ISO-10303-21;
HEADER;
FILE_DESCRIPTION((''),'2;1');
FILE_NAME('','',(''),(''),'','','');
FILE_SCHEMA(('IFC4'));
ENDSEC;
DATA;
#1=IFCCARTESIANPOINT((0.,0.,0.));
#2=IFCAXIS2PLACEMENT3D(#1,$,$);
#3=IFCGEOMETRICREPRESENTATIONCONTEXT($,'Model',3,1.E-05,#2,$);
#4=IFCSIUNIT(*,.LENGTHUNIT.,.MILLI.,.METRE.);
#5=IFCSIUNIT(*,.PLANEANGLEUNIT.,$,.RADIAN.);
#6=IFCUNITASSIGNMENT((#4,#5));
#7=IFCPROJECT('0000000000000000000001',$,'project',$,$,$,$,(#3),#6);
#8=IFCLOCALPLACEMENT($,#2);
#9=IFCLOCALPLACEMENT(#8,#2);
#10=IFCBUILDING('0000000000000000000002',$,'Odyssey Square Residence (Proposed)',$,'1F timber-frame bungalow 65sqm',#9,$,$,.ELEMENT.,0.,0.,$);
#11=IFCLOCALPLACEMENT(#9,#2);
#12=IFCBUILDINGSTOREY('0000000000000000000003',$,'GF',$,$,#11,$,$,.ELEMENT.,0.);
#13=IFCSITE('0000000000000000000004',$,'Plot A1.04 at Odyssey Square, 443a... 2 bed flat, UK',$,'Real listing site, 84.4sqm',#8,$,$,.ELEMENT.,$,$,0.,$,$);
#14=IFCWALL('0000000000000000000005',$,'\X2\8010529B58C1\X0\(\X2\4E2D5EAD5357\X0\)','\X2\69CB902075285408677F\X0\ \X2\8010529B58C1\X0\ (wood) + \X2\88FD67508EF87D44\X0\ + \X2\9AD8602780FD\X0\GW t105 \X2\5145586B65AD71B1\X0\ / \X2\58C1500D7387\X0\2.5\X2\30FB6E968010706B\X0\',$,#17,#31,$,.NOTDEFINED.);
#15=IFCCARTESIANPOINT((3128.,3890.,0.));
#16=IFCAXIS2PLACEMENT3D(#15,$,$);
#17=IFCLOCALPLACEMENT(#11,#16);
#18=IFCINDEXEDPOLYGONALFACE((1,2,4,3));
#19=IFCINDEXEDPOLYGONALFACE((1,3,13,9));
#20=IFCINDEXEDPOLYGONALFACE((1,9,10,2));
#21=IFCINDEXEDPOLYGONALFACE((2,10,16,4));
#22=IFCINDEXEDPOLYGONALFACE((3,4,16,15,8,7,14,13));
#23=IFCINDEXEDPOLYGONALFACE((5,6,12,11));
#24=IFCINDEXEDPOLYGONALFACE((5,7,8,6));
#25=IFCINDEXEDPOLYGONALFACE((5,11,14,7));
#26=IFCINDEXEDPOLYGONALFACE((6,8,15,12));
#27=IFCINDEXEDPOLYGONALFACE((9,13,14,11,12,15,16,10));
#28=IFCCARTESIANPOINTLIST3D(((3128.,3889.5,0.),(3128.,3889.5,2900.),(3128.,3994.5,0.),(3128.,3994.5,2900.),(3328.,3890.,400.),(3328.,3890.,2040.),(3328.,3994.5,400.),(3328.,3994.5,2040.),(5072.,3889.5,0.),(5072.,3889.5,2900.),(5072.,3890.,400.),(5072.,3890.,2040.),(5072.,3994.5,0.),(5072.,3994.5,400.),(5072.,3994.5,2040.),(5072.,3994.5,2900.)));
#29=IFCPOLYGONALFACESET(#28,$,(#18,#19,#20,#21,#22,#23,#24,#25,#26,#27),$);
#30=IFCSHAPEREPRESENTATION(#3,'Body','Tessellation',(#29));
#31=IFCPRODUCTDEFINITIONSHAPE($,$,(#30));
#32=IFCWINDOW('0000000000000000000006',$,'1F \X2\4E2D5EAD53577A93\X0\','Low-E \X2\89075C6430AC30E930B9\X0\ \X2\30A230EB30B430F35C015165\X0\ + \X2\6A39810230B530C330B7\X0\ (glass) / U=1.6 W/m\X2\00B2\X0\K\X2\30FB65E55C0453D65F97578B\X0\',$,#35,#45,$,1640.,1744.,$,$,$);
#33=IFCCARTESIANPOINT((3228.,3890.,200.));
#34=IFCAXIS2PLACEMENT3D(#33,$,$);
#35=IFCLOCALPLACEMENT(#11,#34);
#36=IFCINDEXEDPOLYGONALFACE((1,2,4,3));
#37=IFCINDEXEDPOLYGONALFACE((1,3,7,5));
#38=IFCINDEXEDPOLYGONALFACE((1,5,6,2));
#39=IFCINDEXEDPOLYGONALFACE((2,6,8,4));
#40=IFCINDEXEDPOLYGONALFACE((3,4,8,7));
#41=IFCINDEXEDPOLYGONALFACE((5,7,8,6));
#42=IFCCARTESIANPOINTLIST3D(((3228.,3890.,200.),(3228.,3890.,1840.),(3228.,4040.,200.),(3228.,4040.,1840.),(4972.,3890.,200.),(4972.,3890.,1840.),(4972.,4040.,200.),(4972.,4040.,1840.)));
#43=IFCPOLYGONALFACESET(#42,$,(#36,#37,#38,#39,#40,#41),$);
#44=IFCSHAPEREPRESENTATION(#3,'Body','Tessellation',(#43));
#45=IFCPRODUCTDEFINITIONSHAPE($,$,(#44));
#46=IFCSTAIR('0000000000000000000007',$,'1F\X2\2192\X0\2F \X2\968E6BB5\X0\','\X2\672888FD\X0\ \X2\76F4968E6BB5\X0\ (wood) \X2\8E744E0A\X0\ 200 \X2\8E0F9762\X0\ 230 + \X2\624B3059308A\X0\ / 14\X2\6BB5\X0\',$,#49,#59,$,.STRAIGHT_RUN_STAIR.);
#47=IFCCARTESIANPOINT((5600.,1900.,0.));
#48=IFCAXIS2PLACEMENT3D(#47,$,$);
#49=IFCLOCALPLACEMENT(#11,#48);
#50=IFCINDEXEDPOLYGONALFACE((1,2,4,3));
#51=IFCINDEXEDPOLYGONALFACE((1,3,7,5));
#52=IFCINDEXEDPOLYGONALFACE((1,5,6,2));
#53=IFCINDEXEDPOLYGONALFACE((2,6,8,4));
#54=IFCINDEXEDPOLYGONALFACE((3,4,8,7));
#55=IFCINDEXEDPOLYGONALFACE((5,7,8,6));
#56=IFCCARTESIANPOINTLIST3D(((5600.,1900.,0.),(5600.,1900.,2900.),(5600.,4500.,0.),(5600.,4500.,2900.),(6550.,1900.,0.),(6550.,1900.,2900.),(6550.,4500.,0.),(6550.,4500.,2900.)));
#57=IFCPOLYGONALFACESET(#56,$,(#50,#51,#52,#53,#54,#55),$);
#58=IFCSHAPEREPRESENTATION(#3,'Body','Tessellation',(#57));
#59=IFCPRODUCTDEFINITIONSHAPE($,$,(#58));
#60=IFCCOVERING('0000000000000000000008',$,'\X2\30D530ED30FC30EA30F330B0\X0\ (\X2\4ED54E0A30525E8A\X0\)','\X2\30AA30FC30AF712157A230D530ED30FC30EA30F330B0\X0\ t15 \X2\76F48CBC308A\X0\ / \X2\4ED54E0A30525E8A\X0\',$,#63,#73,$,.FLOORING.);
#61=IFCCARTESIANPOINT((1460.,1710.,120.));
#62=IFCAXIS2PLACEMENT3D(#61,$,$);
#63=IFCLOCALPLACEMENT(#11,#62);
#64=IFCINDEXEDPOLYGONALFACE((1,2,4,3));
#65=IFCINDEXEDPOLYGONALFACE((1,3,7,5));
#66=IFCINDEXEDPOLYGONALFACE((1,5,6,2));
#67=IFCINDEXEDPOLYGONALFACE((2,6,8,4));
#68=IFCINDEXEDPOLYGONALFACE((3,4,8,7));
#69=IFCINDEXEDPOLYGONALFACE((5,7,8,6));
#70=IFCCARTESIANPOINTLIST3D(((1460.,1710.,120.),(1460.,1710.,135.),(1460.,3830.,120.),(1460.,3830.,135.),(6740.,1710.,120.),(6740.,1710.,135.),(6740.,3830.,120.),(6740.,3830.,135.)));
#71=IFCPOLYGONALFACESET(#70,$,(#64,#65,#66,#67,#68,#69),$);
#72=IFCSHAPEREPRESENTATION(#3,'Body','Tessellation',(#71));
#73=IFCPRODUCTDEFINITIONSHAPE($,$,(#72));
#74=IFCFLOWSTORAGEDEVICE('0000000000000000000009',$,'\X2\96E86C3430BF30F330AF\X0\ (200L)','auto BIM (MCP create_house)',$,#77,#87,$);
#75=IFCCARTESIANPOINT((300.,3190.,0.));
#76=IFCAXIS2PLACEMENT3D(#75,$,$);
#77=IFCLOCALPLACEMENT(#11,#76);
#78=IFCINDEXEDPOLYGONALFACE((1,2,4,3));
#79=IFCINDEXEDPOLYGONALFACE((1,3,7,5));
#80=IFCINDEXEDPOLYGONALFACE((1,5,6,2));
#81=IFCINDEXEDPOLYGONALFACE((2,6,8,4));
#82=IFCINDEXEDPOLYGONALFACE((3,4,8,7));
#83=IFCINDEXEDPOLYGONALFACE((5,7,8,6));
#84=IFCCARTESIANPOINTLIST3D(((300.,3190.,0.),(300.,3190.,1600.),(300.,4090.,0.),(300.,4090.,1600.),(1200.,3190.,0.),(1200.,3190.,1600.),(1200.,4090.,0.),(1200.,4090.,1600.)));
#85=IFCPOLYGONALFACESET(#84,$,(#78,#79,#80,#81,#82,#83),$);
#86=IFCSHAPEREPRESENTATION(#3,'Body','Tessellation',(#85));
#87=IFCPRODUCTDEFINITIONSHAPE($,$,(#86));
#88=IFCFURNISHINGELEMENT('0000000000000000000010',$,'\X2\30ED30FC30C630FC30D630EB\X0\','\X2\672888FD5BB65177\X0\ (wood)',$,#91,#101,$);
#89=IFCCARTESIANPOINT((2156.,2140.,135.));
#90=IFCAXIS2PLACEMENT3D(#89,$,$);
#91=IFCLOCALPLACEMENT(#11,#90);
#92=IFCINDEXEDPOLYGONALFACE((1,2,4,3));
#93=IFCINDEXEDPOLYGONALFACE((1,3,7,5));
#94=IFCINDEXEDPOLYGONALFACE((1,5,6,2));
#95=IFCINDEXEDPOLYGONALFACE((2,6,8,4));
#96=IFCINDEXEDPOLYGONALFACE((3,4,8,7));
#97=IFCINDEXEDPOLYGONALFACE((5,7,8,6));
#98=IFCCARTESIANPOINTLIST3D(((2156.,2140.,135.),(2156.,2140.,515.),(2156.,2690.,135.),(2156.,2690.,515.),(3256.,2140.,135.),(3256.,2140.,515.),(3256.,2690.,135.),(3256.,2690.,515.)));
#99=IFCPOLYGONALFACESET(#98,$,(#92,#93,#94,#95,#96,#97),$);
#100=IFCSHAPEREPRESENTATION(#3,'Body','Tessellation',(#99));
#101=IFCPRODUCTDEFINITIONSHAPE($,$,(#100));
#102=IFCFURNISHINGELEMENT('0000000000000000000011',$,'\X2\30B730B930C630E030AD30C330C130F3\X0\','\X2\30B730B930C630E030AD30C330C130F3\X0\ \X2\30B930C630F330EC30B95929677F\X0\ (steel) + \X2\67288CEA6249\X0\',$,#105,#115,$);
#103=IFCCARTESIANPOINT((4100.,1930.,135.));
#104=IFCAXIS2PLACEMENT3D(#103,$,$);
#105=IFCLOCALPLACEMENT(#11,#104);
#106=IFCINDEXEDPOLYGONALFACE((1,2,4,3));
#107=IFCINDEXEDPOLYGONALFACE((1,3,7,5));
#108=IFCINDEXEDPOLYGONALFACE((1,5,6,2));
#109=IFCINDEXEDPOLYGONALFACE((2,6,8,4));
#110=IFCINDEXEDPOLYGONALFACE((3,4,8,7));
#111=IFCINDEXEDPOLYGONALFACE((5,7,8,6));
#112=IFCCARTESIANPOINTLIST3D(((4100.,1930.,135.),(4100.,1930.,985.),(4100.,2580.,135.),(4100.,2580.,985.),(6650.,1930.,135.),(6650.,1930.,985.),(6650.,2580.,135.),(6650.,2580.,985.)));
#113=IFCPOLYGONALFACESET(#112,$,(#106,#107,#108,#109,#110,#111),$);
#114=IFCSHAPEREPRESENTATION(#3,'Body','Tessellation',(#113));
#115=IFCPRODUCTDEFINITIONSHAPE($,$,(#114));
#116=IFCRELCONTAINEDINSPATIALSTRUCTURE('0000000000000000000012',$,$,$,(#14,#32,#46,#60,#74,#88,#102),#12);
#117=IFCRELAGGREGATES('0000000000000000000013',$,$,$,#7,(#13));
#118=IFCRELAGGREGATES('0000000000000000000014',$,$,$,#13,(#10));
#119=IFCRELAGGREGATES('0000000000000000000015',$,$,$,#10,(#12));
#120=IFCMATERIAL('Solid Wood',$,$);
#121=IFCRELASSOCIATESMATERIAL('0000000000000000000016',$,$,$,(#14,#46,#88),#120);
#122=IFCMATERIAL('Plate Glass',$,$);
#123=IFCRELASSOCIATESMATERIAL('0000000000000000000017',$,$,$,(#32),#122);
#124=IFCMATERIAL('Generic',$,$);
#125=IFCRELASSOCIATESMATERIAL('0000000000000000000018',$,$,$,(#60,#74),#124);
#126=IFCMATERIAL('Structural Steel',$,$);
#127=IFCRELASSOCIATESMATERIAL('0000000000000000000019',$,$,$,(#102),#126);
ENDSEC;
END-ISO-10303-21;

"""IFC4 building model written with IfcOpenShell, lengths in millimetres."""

from ifc_helpers import new_model, si_unit, frame, frame_2d, origin, place, context, project, spatial, rectangle, extrude, material, element, fill, save


model = new_model("IFC4")

# Units and contexts
model_context = context("Model", 3, precision=1e-05, world=origin())
ifc_project = project(units=[si_unit("LENGTHUNIT", "METRE", prefix="MILLI"), si_unit("PLANEANGLEUNIT", "RADIAN")], contexts=[model_context])

# Site, building, storey
site_placement = place(None, origin())
site = spatial("IfcSite", under=ifc_project, at=site_placement, Name="Plot A1.04 at Odyssey Square, 443a... 2 bed flat, UK", ObjectType="Real listing site, 84.4sqm", CompositionType="ELEMENT", RefElevation=0.0)
building_placement = place(site_placement, origin())
building = spatial("IfcBuilding", under=site, at=building_placement, Name="Odyssey Square Residence (Proposed)", ObjectType="1F timber-frame bungalow 65sqm", CompositionType="ELEMENT", ElevationOfRefHeight=0.0, ElevationOfTerrain=0.0)
storey_placement = place(building_placement, origin())
storey = spatial("IfcBuildingStorey", under=building, at=storey_placement, Name="GF", CompositionType="ELEMENT", Elevation=0.0)

# Shared definitions
ifc_material_1 = material(Name="Solid Wood")

# Shared definitions
ifc_material_2 = material(Name="Plate Glass")

# Wall, opening, window
wall_1_placement = place(storey_placement, frame((3128.0, 3890.0, 0.0)))
wall_1 = element("IfcWall", 1, at=wall_1_placement, inside=storey, material=ifc_material_1, Name="耐力壁(中庭南)", Description="構造用合板 耐力壁 (wood) + 製材軸組 + 高性能GW t105 充填断熱 / 壁倍率2.5・準耐火", PredefinedType="NOTDEFINED", context=model_context, shape_type="SweptSolid", body=[
    extrude(rectangle(XDim=1944.0, YDim=105.0, at=frame_2d((972.0, 52.0))), frame((3128.0, 3890.0, 0.0)), (0.0, 0.0, 1.0), 2900.0),
])
opening_1_placement = place(storey_placement, frame((3228.0, 3890.0, 200.0)))
opening_1 = element("IfcOpeningElement", 2, at=opening_1_placement, cuts=wall_1, PredefinedType="NOTDEFINED", context=model_context, shape_type="SweptSolid", body=[
    extrude(rectangle(XDim=1744.0, YDim=150.0, at=frame_2d((872.0, 75.0))), frame((3228.0, 3890.0, 200.0)), (0.0, 0.0, 1.0), 1640.0),
])
window_1_placement = place(storey_placement, frame((3228.0, 3890.0, 200.0)))
window_1 = element("IfcWindow", 3, at=window_1_placement, inside=storey, material=ifc_material_2, Name="1F 中庭南窓", Description="Low-E 複層ガラス アルゴン封入 + 樹脂サッシ (glass) / U=1.6 W/m²K・日射取得型", OverallHeight=1640.0, OverallWidth=1744.0, context=model_context, shape_type="SweptSolid", body=[
    extrude(rectangle(XDim=1744.0, YDim=150.0, at=frame_2d((872.0, 75.0))), frame((3228.0, 3890.0, 200.0)), (0.0, 0.0, 1.0), 1640.0),
])
fill(opening_1, window_1)

# Stair
stair_placement = place(storey_placement, frame((5600.0, 1900.0, 0.0)))
element("IfcStair", 4, at=stair_placement, inside=storey, material=ifc_material_1, Name="1F→2F 階段", Description="木製 直階段 (wood) 蹴上 200 踏面 230 + 手すり / 14段", PredefinedType="STRAIGHT_RUN_STAIR", context=model_context, shape_type="SweptSolid", body=[
    extrude(rectangle(XDim=950.0, YDim=2600.0, at=frame_2d((475.0, 1300.0))), frame((5600.0, 1900.0, 0.0)), (0.0, 0.0, 1.0), 2900.0),
])

# Covering
ifc_material_3 = material(Name="Generic")
covering_placement = place(storey_placement, frame((1460.0, 1710.0, 120.0)))
element("IfcCovering", 5, at=covering_placement, inside=storey, material=ifc_material_3, Name="フローリング (仕上げ床)", Description="オーク無垢フローリング t15 直貼り / 仕上げ床", PredefinedType="FLOORING", context=model_context, shape_type="SweptSolid", body=[
    extrude(rectangle(XDim=5280.0, YDim=2120.0, at=frame_2d((2640.0, 1060.0))), frame((1460.0, 1710.0, 120.0)), (0.0, 0.0, 1.0), 15.0),
])

# Flow storage device
flow_storage_device_placement = place(storey_placement, frame((300.0, 3190.0, 0.0)))
element("IfcFlowStorageDevice", 6, at=flow_storage_device_placement, inside=storey, material=ifc_material_3, Name="雨水タンク (200L)", Description="auto BIM (MCP create_house)", context=model_context, shape_type="SweptSolid", body=[
    extrude(rectangle(XDim=900.0, YDim=900.0, at=frame_2d((450.0, 450.0))), frame((300.0, 3190.0, 0.0)), (0.0, 0.0, 1.0), 1600.0),
])

# Furnishing elements
furnishing_1_placement = place(storey_placement, frame((2156.0, 2140.0, 135.0)))
element("IfcFurnishingElement", 7, at=furnishing_1_placement, inside=storey, material=ifc_material_1, Name="ローテーブル", Description="木製家具 (wood)", context=model_context, shape_type="SweptSolid", body=[
    extrude(rectangle(XDim=1100.0, YDim=550.0, at=frame_2d((550.0, 275.0))), frame((2156.0, 2140.0, 135.0)), (0.0, 0.0, 1.0), 380.0),
])
ifc_material_4 = material(Name="Structural Steel")
furnishing_2_placement = place(storey_placement, frame((4100.0, 1930.0, 135.0)))
element("IfcFurnishingElement", 8, at=furnishing_2_placement, inside=storey, material=ifc_material_4, Name="システムキッチン", Description="システムキッチン ステンレス天板 (steel) + 木質扉", context=model_context, shape_type="SweptSolid", body=[
    extrude(rectangle(XDim=2550.0, YDim=650.0, at=frame_2d((1275.0, 325.0))), frame((4100.0, 1930.0, 135.0)), (0.0, 0.0, 1.0), 850.0),
])

save(model, "model.ifc")
